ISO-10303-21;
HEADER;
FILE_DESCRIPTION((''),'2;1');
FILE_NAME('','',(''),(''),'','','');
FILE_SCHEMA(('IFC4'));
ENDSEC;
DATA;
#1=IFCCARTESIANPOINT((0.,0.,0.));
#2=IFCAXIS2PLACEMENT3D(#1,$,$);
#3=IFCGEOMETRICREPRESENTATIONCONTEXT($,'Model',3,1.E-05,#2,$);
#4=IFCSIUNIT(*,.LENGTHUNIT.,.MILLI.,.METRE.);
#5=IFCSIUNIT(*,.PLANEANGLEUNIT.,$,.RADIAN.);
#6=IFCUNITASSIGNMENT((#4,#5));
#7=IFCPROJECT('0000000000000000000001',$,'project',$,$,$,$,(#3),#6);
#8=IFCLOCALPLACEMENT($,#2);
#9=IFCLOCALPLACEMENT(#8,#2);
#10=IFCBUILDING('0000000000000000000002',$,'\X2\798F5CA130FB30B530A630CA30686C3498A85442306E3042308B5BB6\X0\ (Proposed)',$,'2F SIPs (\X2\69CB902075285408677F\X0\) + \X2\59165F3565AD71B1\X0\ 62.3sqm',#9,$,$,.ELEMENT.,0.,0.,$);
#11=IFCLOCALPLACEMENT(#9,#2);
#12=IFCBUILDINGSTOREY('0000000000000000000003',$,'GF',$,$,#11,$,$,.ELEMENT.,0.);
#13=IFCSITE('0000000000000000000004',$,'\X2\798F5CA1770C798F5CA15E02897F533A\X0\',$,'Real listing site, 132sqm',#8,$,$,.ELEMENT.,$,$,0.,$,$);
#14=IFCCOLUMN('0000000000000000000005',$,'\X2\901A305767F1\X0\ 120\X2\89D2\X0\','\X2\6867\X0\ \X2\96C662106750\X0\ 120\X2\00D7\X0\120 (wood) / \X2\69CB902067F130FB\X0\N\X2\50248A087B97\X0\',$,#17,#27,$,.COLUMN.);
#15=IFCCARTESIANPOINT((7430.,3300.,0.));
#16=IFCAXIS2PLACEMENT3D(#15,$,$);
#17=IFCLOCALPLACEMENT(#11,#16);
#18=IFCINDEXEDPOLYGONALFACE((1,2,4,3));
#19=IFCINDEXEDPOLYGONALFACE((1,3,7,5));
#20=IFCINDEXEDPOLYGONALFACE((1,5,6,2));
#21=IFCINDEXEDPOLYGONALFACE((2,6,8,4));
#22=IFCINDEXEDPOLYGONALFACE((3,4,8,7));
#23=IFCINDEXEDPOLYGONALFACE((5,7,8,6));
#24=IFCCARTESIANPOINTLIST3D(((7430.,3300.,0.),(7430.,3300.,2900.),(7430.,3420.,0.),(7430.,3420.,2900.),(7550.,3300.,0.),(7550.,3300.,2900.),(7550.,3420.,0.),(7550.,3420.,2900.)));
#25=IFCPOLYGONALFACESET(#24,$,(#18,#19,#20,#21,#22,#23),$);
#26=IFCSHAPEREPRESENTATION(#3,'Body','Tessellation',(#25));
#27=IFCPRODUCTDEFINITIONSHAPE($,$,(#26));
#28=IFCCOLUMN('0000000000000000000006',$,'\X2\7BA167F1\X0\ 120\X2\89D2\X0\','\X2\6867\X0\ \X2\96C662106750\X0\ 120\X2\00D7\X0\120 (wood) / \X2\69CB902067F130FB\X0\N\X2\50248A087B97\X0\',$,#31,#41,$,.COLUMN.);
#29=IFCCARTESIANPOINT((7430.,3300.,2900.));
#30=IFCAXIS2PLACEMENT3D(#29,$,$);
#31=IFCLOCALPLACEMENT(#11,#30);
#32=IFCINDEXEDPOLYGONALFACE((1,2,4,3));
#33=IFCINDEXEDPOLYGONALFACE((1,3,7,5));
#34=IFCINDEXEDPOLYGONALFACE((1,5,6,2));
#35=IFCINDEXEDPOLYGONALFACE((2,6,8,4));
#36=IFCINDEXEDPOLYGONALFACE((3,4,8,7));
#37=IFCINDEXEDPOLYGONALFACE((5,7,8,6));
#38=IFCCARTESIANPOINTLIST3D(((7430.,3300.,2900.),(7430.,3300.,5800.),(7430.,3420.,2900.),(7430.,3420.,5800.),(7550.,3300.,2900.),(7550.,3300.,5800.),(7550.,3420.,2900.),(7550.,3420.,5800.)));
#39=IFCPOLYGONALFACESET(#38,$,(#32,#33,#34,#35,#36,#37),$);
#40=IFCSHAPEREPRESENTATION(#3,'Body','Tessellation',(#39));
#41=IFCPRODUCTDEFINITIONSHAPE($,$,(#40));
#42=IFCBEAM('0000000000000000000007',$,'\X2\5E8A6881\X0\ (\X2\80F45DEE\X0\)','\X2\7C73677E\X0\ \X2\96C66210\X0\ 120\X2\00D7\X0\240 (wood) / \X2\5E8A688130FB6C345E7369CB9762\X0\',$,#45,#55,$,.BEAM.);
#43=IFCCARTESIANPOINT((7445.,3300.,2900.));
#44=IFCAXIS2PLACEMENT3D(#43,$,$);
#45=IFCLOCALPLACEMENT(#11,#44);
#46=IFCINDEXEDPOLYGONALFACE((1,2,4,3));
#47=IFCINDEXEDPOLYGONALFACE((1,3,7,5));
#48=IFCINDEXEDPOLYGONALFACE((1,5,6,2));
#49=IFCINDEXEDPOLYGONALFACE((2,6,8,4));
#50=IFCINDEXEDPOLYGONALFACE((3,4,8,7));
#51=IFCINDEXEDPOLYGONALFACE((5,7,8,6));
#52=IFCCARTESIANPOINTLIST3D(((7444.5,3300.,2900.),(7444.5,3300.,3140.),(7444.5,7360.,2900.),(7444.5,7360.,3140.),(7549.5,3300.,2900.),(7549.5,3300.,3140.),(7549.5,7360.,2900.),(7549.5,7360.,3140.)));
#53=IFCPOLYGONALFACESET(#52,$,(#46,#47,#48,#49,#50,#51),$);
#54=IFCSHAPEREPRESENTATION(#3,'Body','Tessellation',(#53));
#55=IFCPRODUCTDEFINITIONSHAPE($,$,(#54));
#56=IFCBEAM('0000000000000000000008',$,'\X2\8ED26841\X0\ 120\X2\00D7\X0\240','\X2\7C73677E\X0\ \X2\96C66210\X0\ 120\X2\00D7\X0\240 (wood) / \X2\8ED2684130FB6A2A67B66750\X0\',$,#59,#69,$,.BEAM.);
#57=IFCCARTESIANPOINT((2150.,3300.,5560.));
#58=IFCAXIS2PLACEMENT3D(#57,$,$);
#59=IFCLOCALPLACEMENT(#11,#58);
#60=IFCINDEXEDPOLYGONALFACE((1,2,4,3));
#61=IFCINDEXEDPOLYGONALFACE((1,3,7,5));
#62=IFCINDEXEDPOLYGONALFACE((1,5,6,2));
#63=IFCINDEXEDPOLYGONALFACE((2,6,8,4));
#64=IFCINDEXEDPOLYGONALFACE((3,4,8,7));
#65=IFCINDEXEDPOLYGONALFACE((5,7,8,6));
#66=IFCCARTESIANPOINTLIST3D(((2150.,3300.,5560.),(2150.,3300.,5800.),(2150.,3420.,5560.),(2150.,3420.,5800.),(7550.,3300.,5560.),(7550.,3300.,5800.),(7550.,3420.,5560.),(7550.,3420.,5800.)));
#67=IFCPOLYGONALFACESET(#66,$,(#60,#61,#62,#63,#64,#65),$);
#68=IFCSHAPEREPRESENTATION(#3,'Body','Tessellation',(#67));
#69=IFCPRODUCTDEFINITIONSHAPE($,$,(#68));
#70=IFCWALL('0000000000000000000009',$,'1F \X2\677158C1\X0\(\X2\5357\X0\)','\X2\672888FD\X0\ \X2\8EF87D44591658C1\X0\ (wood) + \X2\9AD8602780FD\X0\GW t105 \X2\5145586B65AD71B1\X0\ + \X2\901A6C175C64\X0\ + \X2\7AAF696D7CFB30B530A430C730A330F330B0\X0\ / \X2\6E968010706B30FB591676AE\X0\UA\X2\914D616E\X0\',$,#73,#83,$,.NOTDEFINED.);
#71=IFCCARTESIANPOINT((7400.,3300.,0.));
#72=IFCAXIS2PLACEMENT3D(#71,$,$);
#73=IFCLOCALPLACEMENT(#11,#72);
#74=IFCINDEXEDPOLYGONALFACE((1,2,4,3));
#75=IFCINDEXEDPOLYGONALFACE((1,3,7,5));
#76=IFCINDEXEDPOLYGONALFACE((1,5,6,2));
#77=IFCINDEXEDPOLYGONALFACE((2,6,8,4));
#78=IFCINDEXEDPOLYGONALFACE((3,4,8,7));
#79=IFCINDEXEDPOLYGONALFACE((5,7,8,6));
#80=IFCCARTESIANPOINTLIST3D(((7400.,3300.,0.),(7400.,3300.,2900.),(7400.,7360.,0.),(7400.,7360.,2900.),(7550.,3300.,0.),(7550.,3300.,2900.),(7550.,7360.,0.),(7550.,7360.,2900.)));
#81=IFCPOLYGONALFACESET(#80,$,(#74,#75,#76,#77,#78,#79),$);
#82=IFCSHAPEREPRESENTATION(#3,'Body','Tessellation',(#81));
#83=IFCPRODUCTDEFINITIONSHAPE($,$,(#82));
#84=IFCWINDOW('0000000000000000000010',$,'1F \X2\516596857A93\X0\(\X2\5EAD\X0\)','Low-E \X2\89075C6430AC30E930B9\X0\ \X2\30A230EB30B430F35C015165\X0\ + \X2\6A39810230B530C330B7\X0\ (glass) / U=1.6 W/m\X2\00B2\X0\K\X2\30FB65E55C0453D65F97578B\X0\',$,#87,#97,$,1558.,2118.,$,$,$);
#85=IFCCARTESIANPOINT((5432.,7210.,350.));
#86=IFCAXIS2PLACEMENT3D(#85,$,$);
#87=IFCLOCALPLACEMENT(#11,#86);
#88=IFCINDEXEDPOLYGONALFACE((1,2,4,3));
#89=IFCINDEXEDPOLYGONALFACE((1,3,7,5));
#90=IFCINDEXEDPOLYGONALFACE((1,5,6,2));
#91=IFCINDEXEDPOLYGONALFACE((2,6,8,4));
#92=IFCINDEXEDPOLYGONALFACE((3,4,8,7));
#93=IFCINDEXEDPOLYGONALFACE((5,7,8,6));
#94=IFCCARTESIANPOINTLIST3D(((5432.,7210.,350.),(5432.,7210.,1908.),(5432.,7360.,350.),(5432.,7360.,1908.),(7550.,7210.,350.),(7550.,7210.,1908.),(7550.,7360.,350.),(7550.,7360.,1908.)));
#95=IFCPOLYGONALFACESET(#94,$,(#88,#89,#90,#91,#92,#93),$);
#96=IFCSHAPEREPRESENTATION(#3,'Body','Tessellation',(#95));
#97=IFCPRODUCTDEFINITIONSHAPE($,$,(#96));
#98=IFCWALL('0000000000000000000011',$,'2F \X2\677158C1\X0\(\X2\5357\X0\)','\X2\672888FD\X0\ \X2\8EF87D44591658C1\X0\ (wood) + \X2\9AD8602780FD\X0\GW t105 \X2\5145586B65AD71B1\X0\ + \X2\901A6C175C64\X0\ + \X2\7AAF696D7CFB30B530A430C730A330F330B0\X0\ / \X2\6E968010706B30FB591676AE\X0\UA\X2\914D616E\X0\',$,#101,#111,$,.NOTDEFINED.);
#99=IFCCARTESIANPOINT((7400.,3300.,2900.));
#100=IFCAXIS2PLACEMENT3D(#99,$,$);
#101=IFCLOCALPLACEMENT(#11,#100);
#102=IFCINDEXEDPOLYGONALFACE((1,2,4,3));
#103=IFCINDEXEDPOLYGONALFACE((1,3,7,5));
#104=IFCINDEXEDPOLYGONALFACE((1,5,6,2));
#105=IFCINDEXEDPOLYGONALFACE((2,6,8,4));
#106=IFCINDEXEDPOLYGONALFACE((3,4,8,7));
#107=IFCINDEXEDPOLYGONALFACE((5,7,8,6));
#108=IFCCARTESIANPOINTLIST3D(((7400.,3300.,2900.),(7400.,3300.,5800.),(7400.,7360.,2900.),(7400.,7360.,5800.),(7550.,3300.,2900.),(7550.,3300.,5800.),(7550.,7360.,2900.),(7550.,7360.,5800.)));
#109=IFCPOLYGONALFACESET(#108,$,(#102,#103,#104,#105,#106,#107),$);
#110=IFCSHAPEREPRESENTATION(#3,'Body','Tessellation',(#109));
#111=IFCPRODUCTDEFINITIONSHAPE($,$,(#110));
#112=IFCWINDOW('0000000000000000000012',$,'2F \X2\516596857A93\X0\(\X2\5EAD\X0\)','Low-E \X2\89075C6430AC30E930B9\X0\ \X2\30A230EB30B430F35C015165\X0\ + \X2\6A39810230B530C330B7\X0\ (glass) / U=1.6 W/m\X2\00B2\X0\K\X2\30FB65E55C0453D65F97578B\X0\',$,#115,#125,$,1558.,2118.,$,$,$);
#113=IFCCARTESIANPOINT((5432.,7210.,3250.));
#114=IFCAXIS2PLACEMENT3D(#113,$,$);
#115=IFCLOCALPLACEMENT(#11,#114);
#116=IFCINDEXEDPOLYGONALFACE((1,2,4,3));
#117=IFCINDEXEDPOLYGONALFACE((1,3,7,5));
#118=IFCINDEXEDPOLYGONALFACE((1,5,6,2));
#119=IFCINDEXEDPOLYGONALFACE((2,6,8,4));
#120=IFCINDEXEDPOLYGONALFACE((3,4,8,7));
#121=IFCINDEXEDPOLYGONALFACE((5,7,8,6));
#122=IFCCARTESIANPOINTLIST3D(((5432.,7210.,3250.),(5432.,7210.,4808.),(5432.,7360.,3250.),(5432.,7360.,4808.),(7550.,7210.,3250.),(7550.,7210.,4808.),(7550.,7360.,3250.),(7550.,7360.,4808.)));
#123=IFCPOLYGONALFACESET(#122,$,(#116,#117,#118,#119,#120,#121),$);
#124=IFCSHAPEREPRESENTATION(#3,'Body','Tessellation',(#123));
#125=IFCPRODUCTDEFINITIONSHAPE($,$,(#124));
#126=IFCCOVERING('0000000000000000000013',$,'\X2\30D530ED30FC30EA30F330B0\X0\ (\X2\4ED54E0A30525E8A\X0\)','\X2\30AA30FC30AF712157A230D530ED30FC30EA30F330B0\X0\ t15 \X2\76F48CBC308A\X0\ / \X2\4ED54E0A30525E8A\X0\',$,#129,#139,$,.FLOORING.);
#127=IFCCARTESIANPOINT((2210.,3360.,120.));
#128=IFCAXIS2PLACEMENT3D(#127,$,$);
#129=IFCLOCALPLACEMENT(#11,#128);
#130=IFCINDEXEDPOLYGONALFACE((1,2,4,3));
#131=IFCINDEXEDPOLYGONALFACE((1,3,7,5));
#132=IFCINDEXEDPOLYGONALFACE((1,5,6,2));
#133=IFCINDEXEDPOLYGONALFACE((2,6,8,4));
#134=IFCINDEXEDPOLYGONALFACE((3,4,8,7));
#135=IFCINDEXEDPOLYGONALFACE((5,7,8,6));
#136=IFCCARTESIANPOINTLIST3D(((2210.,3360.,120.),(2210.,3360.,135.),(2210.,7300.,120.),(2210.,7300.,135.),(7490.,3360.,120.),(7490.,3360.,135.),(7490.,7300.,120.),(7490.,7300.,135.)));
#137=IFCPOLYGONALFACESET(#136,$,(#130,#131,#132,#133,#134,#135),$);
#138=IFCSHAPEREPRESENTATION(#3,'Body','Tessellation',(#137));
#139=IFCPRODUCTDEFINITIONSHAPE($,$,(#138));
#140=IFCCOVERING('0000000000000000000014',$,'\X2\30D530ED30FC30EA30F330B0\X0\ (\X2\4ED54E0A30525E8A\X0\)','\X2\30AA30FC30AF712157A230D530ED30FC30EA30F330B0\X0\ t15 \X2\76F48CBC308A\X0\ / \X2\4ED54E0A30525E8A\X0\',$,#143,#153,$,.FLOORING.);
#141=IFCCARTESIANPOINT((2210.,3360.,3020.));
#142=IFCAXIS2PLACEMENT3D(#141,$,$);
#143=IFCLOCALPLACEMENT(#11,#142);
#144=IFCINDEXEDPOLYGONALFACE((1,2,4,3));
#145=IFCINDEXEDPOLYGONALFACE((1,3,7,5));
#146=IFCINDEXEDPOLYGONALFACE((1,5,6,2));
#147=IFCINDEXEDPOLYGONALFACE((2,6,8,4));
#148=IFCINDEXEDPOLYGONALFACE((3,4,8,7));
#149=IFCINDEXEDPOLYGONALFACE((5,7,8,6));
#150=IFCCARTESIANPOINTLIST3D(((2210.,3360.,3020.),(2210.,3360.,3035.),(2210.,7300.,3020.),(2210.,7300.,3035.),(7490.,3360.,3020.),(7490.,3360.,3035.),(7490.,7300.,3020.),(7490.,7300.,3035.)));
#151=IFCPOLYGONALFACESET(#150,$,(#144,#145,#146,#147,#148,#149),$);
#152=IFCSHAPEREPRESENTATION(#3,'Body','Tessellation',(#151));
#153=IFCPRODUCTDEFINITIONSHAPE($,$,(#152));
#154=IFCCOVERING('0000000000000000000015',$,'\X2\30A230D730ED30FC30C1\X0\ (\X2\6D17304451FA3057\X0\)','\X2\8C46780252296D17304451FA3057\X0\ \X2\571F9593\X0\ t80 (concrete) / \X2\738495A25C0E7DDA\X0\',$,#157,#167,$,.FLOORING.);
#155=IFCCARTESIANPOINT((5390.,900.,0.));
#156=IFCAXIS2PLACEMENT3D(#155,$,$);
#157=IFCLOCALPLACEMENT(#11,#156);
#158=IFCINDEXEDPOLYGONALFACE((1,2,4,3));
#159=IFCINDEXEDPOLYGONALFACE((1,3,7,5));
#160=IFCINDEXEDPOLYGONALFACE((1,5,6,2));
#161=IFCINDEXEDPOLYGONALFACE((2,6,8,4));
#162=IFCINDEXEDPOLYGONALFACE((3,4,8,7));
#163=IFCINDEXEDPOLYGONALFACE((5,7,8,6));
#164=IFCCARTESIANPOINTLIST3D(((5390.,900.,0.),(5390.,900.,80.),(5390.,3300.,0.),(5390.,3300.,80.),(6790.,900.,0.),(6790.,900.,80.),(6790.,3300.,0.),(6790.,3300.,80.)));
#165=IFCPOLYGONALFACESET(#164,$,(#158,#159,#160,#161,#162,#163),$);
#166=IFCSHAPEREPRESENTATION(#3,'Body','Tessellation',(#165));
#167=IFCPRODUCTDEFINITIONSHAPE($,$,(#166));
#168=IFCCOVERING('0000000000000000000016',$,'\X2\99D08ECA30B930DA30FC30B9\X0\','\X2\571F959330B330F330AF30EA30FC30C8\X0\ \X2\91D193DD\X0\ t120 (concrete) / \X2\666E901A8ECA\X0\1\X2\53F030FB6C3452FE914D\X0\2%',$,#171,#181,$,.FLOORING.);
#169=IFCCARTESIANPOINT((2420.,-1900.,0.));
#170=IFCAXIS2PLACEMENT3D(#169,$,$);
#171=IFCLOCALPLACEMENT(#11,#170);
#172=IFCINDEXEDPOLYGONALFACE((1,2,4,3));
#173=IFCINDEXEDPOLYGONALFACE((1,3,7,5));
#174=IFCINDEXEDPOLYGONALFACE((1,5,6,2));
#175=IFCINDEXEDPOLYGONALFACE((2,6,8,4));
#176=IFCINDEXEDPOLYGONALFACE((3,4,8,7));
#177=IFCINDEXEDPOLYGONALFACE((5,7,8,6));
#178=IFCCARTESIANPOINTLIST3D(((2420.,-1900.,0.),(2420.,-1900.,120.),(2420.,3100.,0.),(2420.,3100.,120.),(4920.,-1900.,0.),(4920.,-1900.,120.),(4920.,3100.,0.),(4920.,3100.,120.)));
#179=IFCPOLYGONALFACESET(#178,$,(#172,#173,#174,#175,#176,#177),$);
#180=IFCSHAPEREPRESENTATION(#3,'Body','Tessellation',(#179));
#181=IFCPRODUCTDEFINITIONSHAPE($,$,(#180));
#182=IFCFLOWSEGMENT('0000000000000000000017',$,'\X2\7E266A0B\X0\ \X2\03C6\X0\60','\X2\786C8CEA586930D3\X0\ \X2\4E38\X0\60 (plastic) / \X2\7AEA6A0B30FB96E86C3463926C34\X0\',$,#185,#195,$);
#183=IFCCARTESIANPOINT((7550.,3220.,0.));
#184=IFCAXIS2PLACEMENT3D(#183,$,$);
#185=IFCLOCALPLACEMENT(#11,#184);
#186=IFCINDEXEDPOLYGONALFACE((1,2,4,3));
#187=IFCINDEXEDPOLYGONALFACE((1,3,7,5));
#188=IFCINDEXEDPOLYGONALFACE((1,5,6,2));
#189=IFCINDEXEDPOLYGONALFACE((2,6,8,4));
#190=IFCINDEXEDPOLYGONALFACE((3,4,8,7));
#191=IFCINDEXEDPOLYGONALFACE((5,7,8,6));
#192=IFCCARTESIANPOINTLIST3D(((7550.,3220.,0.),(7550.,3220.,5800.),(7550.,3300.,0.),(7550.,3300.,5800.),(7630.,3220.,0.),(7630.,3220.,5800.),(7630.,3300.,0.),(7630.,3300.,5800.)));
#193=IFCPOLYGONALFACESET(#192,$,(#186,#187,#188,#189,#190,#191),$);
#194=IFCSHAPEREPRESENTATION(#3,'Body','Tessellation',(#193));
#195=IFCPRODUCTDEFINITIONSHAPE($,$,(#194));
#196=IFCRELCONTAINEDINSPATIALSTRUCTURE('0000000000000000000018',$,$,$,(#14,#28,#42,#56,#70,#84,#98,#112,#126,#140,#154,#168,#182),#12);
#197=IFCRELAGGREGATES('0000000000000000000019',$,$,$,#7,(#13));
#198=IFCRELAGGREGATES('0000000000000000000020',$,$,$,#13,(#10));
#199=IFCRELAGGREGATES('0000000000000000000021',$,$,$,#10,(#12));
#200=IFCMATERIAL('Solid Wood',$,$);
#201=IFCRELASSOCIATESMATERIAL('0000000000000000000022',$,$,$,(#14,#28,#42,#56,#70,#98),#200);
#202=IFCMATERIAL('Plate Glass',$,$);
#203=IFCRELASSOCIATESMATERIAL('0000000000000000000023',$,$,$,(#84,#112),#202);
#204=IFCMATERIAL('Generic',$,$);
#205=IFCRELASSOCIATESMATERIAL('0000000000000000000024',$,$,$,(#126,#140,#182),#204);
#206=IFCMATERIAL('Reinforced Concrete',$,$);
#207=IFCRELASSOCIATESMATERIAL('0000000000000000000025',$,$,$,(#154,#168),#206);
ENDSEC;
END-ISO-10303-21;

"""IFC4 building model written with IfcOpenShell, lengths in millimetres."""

from ifc_helpers import new_model, si_unit, frame, frame_2d, origin, place, context, project, spatial, rectangle, extrude, material, element, fill, save


model = new_model("IFC4")

# Units and contexts
model_context = context("Model", 3, precision=1e-05, world=origin())
ifc_project = project(units=[si_unit("LENGTHUNIT", "METRE", prefix="MILLI"), si_unit("PLANEANGLEUNIT", "RADIAN")], contexts=[model_context])

# Site, building, storey
site_placement = place(None, origin())
site = spatial("IfcSite", under=ifc_project, at=site_placement, Name="福岡県福岡市西区", ObjectType="Real listing site, 132sqm", CompositionType="ELEMENT", RefElevation=0.0)
building_placement = place(site_placement, origin())
building = spatial("IfcBuilding", under=site, at=building_placement, Name="福岡・サウナと水風呂のある家 (Proposed)", ObjectType="2F SIPs (構造用合板) + 外張断熱 62.3sqm", CompositionType="ELEMENT", ElevationOfRefHeight=0.0, ElevationOfTerrain=0.0)
storey_placement = place(building_placement, origin())
storey = spatial("IfcBuildingStorey", under=building, at=storey_placement, Name="GF", CompositionType="ELEMENT", Elevation=0.0)

# Columns
ifc_material_1 = material(Name="Solid Wood")
column_1_placement = place(storey_placement, frame((7430.0, 3300.0, 0.0)))
element("IfcColumn", 1, at=column_1_placement, inside=storey, material=ifc_material_1, Name="通し柱 120角", Description="桧 集成材 120×120 (wood) / 構造柱・N値計算", PredefinedType="COLUMN", context=model_context, shape_type="SweptSolid", body=[
    extrude(rectangle(XDim=120.0, YDim=120.0, at=frame_2d((60.0, 60.0))), frame((7430.0, 3300.0, 0.0)), (0.0, 0.0, 1.0), 2900.0),
])
column_2_placement = place(storey_placement, frame((7430.0, 3300.0, 2900.0)))
element("IfcColumn", 2, at=column_2_placement, inside=storey, material=ifc_material_1, Name="管柱 120角", Description="桧 集成材 120×120 (wood) / 構造柱・N値計算", PredefinedType="COLUMN", context=model_context, shape_type="SweptSolid", body=[
    extrude(rectangle(XDim=120.0, YDim=120.0, at=frame_2d((60.0, 60.0))), frame((7430.0, 3300.0, 2900.0)), (0.0, 0.0, 1.0), 2900.0),
])

# Beams
beam_1_placement = place(storey_placement, frame((7445.0, 3300.0, 2900.0)))
element("IfcBeam", 3, at=beam_1_placement, inside=storey, material=ifc_material_1, Name="床梁 (胴差)", Description="米松 集成 120×240 (wood) / 床梁・水平構面", PredefinedType="BEAM", context=model_context, shape_type="SweptSolid", body=[
    extrude(rectangle(XDim=105.0, YDim=4060.0, at=frame_2d((52.0, 2030.0))), frame((7445.0, 3300.0, 2900.0)), (0.0, 0.0, 1.0), 240.0),
])
beam_2_placement = place(storey_placement, frame((2150.0, 3300.0, 5560.0)))
element("IfcBeam", 4, at=beam_2_placement, inside=storey, material=ifc_material_1, Name="軒桁 120×240", Description="米松 集成 120×240 (wood) / 軒桁・横架材", PredefinedType="BEAM", context=model_context, shape_type="SweptSolid", body=[
    extrude(rectangle(XDim=5400.0, YDim=120.0, at=frame_2d((2700.0, 60.0))), frame((2150.0, 3300.0, 5560.0)), (0.0, 0.0, 1.0), 240.0),
])

# Wall, opening, window
wall_1_placement = place(storey_placement, frame((7400.0, 3300.0, 0.0)))
wall_1 = element("IfcWall", 5, at=wall_1_placement, inside=storey, material=ifc_material_1, Name="1F 東壁(南)", Description="木製 軸組外壁 (wood) + 高性能GW t105 充填断熱 + 通気層 + 窯業系サイディング / 準耐火・外皮UA配慮", PredefinedType="NOTDEFINED", context=model_context, shape_type="SweptSolid", body=[
    extrude(rectangle(XDim=150.0, YDim=4060.0, at=frame_2d((75.0, 2030.0))), frame((7400.0, 3300.0, 0.0)), (0.0, 0.0, 1.0), 2900.0),
])
opening_1_placement = place(storey_placement, frame((5432.0, 7210.0, 350.0)))
opening_1 = element("IfcOpeningElement", 6, at=opening_1_placement, cuts=wall_1, PredefinedType="NOTDEFINED", context=model_context, shape_type="SweptSolid", body=[
    extrude(rectangle(XDim=2118.0, YDim=150.0, at=frame_2d((1059.0, 75.0))), frame((5432.0, 7210.0, 350.0)), (0.0, 0.0, 1.0), 1558.0),
])
ifc_material_2 = material(Name="Plate Glass")
window_1_placement = place(storey_placement, frame((5432.0, 7210.0, 350.0)))
window_1 = element("IfcWindow", 7, at=window_1_placement, inside=storey, material=ifc_material_2, Name="1F 入隅窓(庭)", Description="Low-E 複層ガラス アルゴン封入 + 樹脂サッシ (glass) / U=1.6 W/m²K・日射取得型", OverallHeight=1558.0, OverallWidth=2118.0, context=model_context, shape_type="SweptSolid", body=[
    extrude(rectangle(XDim=2118.0, YDim=150.0, at=frame_2d((1059.0, 75.0))), frame((5432.0, 7210.0, 350.0)), (0.0, 0.0, 1.0), 1558.0),
])
fill(opening_1, window_1)

# Wall, opening, window
wall_2_placement = place(storey_placement, frame((7400.0, 3300.0, 2900.0)))
wall_2 = element("IfcWall", 8, at=wall_2_placement, inside=storey, material=ifc_material_1, Name="2F 東壁(南)", Description="木製 軸組外壁 (wood) + 高性能GW t105 充填断熱 + 通気層 + 窯業系サイディング / 準耐火・外皮UA配慮", PredefinedType="NOTDEFINED", context=model_context, shape_type="SweptSolid", body=[
    extrude(rectangle(XDim=150.0, YDim=4060.0, at=frame_2d((75.0, 2030.0))), frame((7400.0, 3300.0, 2900.0)), (0.0, 0.0, 1.0), 2900.0),
])
opening_2_placement = place(storey_placement, frame((5432.0, 7210.0, 3250.0)))
opening_2 = element("IfcOpeningElement", 9, at=opening_2_placement, cuts=wall_2, PredefinedType="NOTDEFINED", context=model_context, shape_type="SweptSolid", body=[
    extrude(rectangle(XDim=2118.0, YDim=150.0, at=frame_2d((1059.0, 75.0))), frame((5432.0, 7210.0, 3250.0)), (0.0, 0.0, 1.0), 1558.0),
])
window_2_placement = place(storey_placement, frame((5432.0, 7210.0, 3250.0)))
window_2 = element("IfcWindow", 10, at=window_2_placement, inside=storey, material=ifc_material_2, Name="2F 入隅窓(庭)", Description="Low-E 複層ガラス アルゴン封入 + 樹脂サッシ (glass) / U=1.6 W/m²K・日射取得型", OverallHeight=1558.0, OverallWidth=2118.0, context=model_context, shape_type="SweptSolid", body=[
    extrude(rectangle(XDim=2118.0, YDim=150.0, at=frame_2d((1059.0, 75.0))), frame((5432.0, 7210.0, 3250.0)), (0.0, 0.0, 1.0), 1558.0),
])
fill(opening_2, window_2)

# Coverings
ifc_material_3 = material(Name="Generic")
covering_1_placement = place(storey_placement, frame((2210.0, 3360.0, 120.0)))
element("IfcCovering", 11, at=covering_1_placement, inside=storey, material=ifc_material_3, Name="フローリング (仕上げ床)", Description="オーク無垢フローリング t15 直貼り / 仕上げ床", PredefinedType="FLOORING", context=model_context, shape_type="SweptSolid", body=[
    extrude(rectangle(XDim=5280.0, YDim=3940.0, at=frame_2d((2640.0, 1970.0))), frame((2210.0, 3360.0, 120.0)), (0.0, 0.0, 1.0), 15.0),
])
covering_2_placement = place(storey_placement, frame((2210.0, 3360.0, 3020.0)))
element("IfcCovering", 12, at=covering_2_placement, inside=storey, material=ifc_material_3, Name="フローリング (仕上げ床)", Description="オーク無垢フローリング t15 直貼り / 仕上げ床", PredefinedType="FLOORING", context=model_context, shape_type="SweptSolid", body=[
    extrude(rectangle(XDim=5280.0, YDim=3940.0, at=frame_2d((2640.0, 1970.0))), frame((2210.0, 3360.0, 3020.0)), (0.0, 0.0, 1.0), 15.0),
])
ifc_material_4 = material(Name="Reinforced Concrete")
covering_3_placement = place(storey_placement, frame((5390.0, 900.0, 0.0)))
element("IfcCovering", 13, at=covering_3_placement, inside=storey, material=ifc_material_4, Name="アプローチ (洗い出し)", Description="豆砂利洗い出し 土間 t80 (concrete) / 玄関導線", PredefinedType="FLOORING", context=model_context, shape_type="SweptSolid", body=[
    extrude(rectangle(XDim=1400.0, YDim=2400.0, at=frame_2d((700.0, 1200.0))), frame((5390.0, 900.0, 0.0)), (0.0, 0.0, 1.0), 80.0),
])
covering_4_placement = place(storey_placement, frame((2420.0, -1900.0, 0.0)))
element("IfcCovering", 14, at=covering_4_placement, inside=storey, material=ifc_material_4, Name="駐車スペース", Description="土間コンクリート 金鏝 t120 (concrete) / 普通車1台・水勾配2%", PredefinedType="FLOORING", context=model_context, shape_type="SweptSolid", body=[
    extrude(rectangle(XDim=2500.0, YDim=5000.0, at=frame_2d((1250.0, 2500.0))), frame((2420.0, -1900.0, 0.0)), (0.0, 0.0, 1.0), 120.0),
])

# Flow segment
flow_segment_placement = place(storey_placement, frame((7550.0, 3220.0, 0.0)))
element("IfcFlowSegment", 15, at=flow_segment_placement, inside=storey, material=ifc_material_3, Name="縦樋 φ60", Description="硬質塩ビ 丸60 (plastic) / 竪樋・雨水排水", context=model_context, shape_type="SweptSolid", body=[
    extrude(rectangle(XDim=80.0, YDim=80.0, at=frame_2d((40.0, 40.0))), frame((7550.0, 3220.0, 0.0)), (0.0, 0.0, 1.0), 5800.0),
])

save(model, "model.ifc")
